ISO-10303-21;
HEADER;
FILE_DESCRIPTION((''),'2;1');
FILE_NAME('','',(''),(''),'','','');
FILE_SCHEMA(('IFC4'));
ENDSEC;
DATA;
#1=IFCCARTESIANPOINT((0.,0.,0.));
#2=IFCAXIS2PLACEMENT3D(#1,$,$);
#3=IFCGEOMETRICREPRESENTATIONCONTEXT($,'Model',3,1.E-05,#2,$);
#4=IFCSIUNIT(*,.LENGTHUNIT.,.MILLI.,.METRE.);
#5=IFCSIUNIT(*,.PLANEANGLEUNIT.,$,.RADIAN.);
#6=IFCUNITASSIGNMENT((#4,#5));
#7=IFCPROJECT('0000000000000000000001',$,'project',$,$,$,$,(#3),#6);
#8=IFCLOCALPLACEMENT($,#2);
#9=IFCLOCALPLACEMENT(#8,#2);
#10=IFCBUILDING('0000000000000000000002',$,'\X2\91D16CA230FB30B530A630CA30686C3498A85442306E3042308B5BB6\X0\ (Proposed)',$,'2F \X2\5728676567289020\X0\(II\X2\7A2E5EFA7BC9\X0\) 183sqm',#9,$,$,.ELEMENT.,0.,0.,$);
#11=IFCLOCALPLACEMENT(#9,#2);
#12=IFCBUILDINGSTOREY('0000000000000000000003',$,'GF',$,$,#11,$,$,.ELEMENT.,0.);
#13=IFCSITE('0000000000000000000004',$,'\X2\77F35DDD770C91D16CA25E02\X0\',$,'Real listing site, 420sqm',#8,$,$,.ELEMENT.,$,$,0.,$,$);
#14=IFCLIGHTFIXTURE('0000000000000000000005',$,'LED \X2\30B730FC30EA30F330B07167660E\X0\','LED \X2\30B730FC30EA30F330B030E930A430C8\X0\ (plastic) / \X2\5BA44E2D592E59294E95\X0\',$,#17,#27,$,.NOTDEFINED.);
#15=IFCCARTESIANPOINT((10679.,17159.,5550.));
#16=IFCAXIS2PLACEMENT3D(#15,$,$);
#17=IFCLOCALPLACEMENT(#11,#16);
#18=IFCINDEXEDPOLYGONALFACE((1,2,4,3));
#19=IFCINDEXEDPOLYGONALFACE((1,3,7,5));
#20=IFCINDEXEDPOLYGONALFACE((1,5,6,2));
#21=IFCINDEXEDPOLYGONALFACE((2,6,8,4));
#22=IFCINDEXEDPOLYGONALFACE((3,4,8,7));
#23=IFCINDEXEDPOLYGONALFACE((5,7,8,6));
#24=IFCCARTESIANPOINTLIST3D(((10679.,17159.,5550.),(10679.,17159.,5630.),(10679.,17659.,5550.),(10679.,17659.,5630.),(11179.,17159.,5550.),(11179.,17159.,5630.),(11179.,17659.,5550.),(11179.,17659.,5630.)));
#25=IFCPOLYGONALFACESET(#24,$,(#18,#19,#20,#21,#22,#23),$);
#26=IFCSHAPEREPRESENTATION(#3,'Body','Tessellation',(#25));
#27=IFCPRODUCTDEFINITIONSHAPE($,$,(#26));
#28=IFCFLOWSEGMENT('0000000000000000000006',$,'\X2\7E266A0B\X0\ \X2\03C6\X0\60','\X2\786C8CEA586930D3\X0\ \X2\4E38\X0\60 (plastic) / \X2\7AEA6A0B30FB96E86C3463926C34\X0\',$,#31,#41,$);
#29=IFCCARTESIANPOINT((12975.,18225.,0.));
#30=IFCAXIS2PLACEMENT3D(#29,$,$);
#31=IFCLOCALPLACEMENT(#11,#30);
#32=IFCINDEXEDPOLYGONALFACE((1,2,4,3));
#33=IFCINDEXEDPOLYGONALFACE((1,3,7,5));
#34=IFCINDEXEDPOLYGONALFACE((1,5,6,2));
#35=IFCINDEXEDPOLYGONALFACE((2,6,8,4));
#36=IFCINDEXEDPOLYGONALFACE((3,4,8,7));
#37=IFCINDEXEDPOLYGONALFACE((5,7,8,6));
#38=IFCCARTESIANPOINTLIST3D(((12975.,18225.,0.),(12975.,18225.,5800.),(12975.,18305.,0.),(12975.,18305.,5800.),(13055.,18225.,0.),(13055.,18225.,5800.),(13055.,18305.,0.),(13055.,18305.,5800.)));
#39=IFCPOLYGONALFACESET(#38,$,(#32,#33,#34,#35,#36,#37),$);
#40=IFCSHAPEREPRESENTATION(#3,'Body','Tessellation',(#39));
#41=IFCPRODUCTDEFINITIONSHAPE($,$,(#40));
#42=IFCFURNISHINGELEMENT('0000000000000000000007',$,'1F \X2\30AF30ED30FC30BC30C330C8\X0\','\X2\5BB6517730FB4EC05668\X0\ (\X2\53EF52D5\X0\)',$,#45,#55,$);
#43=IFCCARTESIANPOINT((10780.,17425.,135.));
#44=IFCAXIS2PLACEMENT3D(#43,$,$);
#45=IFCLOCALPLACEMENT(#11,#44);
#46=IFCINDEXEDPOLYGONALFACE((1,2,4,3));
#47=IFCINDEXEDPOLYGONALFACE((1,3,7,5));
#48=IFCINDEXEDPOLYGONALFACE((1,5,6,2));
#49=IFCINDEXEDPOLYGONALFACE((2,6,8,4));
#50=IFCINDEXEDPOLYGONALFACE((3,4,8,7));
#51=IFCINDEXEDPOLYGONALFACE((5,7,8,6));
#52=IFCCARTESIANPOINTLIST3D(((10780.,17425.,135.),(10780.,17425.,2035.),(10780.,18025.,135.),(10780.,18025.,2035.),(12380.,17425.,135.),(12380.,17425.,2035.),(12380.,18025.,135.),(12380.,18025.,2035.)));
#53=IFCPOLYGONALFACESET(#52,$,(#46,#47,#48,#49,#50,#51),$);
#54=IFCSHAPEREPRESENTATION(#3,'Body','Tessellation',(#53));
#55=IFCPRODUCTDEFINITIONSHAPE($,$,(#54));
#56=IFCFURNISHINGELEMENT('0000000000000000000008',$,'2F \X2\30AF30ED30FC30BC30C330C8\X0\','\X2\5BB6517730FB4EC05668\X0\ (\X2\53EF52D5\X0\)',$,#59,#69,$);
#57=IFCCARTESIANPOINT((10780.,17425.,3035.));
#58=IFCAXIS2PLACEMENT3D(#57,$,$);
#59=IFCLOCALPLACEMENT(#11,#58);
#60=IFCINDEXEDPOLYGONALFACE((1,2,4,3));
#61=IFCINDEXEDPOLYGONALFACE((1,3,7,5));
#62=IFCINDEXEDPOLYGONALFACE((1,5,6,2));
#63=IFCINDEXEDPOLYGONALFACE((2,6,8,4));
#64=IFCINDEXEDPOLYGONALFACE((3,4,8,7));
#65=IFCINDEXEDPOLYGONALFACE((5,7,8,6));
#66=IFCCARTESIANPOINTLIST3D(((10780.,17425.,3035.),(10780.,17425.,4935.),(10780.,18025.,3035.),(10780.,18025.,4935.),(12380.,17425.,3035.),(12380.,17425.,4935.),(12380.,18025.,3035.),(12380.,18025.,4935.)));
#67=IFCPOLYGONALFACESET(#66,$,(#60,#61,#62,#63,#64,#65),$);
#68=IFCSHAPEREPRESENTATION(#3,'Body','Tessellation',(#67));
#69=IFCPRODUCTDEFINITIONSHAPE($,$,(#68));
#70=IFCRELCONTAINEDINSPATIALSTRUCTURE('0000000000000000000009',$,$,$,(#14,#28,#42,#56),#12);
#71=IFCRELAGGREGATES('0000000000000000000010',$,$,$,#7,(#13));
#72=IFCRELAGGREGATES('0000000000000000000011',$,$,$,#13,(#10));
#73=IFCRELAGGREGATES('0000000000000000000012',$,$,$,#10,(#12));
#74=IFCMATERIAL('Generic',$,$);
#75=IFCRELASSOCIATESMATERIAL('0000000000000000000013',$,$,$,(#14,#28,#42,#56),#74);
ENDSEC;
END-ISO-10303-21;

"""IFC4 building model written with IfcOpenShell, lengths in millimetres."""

from ifc_helpers import new_model, si_unit, frame, frame_2d, origin, place, context, project, spatial, rectangle, extrude, material, element, save


model = new_model("IFC4")

# Units and contexts
model_context = context("Model", 3, precision=1e-05, world=origin())
ifc_project = project(units=[si_unit("LENGTHUNIT", "METRE", prefix="MILLI"), si_unit("PLANEANGLEUNIT", "RADIAN")], contexts=[model_context])

# Site, building, storey
site_placement = place(None, origin())
site = spatial("IfcSite", under=ifc_project, at=site_placement, Name="石川県金沢市", ObjectType="Real listing site, 420sqm", CompositionType="ELEMENT", RefElevation=0.0)
building_placement = place(site_placement, origin())
building = spatial("IfcBuilding", under=site, at=building_placement, Name="金沢・サウナと水風呂のある家 (Proposed)", ObjectType="2F 在来木造(II種建築) 183sqm", CompositionType="ELEMENT", ElevationOfRefHeight=0.0, ElevationOfTerrain=0.0)
storey_placement = place(building_placement, origin())
storey = spatial("IfcBuildingStorey", under=building, at=storey_placement, Name="GF", CompositionType="ELEMENT", Elevation=0.0)

# Shared definitions
ifc_material_1 = material(Name="Generic")

# Light fixture
light_fixture_1_placement = place(storey_placement, frame((10679.0, 17159.0, 5550.0)))
element("IfcLightFixture", 1, at=light_fixture_1_placement, inside=storey, material=ifc_material_1, Name="LED シーリング照明", Description="LED シーリングライト (plastic) / 室中央天井", PredefinedType="NOTDEFINED", context=model_context, shape_type="SweptSolid", body=[
    extrude(rectangle(XDim=500.0, YDim=500.0, at=frame_2d((250.0, 250.0))), frame((10679.0, 17159.0, 5550.0)), (0.0, 0.0, 1.0), 80.0),
])

# Flow segment
flow_segment_placement = place(storey_placement, frame((12975.0, 18225.0, 0.0)))
element("IfcFlowSegment", 2, at=flow_segment_placement, inside=storey, material=ifc_material_1, Name="縦樋 φ60", Description="硬質塩ビ 丸60 (plastic) / 竪樋・雨水排水", context=model_context, shape_type="SweptSolid", body=[
    extrude(rectangle(XDim=80.0, YDim=80.0, at=frame_2d((40.0, 40.0))), frame((12975.0, 18225.0, 0.0)), (0.0, 0.0, 1.0), 5800.0),
])

# Furnishing elements
furnishing_1_placement = place(storey_placement, frame((10780.0, 17425.0, 135.0)))
element("IfcFurnishingElement", 3, at=furnishing_1_placement, inside=storey, material=ifc_material_1, Name="1F クローゼット", Description="家具・什器 (可動)", context=model_context, shape_type="SweptSolid", body=[
    extrude(rectangle(XDim=1600.0, YDim=600.0, at=frame_2d((800.0, 300.0))), frame((10780.0, 17425.0, 135.0)), (0.0, 0.0, 1.0), 1900.0),
])
furnishing_2_placement = place(storey_placement, frame((10780.0, 17425.0, 3035.0)))
element("IfcFurnishingElement", 4, at=furnishing_2_placement, inside=storey, material=ifc_material_1, Name="2F クローゼット", Description="家具・什器 (可動)", context=model_context, shape_type="SweptSolid", body=[
    extrude(rectangle(XDim=1600.0, YDim=600.0, at=frame_2d((800.0, 300.0))), frame((10780.0, 17425.0, 3035.0)), (0.0, 0.0, 1.0), 1900.0),
])

save(model, "model.ifc")
